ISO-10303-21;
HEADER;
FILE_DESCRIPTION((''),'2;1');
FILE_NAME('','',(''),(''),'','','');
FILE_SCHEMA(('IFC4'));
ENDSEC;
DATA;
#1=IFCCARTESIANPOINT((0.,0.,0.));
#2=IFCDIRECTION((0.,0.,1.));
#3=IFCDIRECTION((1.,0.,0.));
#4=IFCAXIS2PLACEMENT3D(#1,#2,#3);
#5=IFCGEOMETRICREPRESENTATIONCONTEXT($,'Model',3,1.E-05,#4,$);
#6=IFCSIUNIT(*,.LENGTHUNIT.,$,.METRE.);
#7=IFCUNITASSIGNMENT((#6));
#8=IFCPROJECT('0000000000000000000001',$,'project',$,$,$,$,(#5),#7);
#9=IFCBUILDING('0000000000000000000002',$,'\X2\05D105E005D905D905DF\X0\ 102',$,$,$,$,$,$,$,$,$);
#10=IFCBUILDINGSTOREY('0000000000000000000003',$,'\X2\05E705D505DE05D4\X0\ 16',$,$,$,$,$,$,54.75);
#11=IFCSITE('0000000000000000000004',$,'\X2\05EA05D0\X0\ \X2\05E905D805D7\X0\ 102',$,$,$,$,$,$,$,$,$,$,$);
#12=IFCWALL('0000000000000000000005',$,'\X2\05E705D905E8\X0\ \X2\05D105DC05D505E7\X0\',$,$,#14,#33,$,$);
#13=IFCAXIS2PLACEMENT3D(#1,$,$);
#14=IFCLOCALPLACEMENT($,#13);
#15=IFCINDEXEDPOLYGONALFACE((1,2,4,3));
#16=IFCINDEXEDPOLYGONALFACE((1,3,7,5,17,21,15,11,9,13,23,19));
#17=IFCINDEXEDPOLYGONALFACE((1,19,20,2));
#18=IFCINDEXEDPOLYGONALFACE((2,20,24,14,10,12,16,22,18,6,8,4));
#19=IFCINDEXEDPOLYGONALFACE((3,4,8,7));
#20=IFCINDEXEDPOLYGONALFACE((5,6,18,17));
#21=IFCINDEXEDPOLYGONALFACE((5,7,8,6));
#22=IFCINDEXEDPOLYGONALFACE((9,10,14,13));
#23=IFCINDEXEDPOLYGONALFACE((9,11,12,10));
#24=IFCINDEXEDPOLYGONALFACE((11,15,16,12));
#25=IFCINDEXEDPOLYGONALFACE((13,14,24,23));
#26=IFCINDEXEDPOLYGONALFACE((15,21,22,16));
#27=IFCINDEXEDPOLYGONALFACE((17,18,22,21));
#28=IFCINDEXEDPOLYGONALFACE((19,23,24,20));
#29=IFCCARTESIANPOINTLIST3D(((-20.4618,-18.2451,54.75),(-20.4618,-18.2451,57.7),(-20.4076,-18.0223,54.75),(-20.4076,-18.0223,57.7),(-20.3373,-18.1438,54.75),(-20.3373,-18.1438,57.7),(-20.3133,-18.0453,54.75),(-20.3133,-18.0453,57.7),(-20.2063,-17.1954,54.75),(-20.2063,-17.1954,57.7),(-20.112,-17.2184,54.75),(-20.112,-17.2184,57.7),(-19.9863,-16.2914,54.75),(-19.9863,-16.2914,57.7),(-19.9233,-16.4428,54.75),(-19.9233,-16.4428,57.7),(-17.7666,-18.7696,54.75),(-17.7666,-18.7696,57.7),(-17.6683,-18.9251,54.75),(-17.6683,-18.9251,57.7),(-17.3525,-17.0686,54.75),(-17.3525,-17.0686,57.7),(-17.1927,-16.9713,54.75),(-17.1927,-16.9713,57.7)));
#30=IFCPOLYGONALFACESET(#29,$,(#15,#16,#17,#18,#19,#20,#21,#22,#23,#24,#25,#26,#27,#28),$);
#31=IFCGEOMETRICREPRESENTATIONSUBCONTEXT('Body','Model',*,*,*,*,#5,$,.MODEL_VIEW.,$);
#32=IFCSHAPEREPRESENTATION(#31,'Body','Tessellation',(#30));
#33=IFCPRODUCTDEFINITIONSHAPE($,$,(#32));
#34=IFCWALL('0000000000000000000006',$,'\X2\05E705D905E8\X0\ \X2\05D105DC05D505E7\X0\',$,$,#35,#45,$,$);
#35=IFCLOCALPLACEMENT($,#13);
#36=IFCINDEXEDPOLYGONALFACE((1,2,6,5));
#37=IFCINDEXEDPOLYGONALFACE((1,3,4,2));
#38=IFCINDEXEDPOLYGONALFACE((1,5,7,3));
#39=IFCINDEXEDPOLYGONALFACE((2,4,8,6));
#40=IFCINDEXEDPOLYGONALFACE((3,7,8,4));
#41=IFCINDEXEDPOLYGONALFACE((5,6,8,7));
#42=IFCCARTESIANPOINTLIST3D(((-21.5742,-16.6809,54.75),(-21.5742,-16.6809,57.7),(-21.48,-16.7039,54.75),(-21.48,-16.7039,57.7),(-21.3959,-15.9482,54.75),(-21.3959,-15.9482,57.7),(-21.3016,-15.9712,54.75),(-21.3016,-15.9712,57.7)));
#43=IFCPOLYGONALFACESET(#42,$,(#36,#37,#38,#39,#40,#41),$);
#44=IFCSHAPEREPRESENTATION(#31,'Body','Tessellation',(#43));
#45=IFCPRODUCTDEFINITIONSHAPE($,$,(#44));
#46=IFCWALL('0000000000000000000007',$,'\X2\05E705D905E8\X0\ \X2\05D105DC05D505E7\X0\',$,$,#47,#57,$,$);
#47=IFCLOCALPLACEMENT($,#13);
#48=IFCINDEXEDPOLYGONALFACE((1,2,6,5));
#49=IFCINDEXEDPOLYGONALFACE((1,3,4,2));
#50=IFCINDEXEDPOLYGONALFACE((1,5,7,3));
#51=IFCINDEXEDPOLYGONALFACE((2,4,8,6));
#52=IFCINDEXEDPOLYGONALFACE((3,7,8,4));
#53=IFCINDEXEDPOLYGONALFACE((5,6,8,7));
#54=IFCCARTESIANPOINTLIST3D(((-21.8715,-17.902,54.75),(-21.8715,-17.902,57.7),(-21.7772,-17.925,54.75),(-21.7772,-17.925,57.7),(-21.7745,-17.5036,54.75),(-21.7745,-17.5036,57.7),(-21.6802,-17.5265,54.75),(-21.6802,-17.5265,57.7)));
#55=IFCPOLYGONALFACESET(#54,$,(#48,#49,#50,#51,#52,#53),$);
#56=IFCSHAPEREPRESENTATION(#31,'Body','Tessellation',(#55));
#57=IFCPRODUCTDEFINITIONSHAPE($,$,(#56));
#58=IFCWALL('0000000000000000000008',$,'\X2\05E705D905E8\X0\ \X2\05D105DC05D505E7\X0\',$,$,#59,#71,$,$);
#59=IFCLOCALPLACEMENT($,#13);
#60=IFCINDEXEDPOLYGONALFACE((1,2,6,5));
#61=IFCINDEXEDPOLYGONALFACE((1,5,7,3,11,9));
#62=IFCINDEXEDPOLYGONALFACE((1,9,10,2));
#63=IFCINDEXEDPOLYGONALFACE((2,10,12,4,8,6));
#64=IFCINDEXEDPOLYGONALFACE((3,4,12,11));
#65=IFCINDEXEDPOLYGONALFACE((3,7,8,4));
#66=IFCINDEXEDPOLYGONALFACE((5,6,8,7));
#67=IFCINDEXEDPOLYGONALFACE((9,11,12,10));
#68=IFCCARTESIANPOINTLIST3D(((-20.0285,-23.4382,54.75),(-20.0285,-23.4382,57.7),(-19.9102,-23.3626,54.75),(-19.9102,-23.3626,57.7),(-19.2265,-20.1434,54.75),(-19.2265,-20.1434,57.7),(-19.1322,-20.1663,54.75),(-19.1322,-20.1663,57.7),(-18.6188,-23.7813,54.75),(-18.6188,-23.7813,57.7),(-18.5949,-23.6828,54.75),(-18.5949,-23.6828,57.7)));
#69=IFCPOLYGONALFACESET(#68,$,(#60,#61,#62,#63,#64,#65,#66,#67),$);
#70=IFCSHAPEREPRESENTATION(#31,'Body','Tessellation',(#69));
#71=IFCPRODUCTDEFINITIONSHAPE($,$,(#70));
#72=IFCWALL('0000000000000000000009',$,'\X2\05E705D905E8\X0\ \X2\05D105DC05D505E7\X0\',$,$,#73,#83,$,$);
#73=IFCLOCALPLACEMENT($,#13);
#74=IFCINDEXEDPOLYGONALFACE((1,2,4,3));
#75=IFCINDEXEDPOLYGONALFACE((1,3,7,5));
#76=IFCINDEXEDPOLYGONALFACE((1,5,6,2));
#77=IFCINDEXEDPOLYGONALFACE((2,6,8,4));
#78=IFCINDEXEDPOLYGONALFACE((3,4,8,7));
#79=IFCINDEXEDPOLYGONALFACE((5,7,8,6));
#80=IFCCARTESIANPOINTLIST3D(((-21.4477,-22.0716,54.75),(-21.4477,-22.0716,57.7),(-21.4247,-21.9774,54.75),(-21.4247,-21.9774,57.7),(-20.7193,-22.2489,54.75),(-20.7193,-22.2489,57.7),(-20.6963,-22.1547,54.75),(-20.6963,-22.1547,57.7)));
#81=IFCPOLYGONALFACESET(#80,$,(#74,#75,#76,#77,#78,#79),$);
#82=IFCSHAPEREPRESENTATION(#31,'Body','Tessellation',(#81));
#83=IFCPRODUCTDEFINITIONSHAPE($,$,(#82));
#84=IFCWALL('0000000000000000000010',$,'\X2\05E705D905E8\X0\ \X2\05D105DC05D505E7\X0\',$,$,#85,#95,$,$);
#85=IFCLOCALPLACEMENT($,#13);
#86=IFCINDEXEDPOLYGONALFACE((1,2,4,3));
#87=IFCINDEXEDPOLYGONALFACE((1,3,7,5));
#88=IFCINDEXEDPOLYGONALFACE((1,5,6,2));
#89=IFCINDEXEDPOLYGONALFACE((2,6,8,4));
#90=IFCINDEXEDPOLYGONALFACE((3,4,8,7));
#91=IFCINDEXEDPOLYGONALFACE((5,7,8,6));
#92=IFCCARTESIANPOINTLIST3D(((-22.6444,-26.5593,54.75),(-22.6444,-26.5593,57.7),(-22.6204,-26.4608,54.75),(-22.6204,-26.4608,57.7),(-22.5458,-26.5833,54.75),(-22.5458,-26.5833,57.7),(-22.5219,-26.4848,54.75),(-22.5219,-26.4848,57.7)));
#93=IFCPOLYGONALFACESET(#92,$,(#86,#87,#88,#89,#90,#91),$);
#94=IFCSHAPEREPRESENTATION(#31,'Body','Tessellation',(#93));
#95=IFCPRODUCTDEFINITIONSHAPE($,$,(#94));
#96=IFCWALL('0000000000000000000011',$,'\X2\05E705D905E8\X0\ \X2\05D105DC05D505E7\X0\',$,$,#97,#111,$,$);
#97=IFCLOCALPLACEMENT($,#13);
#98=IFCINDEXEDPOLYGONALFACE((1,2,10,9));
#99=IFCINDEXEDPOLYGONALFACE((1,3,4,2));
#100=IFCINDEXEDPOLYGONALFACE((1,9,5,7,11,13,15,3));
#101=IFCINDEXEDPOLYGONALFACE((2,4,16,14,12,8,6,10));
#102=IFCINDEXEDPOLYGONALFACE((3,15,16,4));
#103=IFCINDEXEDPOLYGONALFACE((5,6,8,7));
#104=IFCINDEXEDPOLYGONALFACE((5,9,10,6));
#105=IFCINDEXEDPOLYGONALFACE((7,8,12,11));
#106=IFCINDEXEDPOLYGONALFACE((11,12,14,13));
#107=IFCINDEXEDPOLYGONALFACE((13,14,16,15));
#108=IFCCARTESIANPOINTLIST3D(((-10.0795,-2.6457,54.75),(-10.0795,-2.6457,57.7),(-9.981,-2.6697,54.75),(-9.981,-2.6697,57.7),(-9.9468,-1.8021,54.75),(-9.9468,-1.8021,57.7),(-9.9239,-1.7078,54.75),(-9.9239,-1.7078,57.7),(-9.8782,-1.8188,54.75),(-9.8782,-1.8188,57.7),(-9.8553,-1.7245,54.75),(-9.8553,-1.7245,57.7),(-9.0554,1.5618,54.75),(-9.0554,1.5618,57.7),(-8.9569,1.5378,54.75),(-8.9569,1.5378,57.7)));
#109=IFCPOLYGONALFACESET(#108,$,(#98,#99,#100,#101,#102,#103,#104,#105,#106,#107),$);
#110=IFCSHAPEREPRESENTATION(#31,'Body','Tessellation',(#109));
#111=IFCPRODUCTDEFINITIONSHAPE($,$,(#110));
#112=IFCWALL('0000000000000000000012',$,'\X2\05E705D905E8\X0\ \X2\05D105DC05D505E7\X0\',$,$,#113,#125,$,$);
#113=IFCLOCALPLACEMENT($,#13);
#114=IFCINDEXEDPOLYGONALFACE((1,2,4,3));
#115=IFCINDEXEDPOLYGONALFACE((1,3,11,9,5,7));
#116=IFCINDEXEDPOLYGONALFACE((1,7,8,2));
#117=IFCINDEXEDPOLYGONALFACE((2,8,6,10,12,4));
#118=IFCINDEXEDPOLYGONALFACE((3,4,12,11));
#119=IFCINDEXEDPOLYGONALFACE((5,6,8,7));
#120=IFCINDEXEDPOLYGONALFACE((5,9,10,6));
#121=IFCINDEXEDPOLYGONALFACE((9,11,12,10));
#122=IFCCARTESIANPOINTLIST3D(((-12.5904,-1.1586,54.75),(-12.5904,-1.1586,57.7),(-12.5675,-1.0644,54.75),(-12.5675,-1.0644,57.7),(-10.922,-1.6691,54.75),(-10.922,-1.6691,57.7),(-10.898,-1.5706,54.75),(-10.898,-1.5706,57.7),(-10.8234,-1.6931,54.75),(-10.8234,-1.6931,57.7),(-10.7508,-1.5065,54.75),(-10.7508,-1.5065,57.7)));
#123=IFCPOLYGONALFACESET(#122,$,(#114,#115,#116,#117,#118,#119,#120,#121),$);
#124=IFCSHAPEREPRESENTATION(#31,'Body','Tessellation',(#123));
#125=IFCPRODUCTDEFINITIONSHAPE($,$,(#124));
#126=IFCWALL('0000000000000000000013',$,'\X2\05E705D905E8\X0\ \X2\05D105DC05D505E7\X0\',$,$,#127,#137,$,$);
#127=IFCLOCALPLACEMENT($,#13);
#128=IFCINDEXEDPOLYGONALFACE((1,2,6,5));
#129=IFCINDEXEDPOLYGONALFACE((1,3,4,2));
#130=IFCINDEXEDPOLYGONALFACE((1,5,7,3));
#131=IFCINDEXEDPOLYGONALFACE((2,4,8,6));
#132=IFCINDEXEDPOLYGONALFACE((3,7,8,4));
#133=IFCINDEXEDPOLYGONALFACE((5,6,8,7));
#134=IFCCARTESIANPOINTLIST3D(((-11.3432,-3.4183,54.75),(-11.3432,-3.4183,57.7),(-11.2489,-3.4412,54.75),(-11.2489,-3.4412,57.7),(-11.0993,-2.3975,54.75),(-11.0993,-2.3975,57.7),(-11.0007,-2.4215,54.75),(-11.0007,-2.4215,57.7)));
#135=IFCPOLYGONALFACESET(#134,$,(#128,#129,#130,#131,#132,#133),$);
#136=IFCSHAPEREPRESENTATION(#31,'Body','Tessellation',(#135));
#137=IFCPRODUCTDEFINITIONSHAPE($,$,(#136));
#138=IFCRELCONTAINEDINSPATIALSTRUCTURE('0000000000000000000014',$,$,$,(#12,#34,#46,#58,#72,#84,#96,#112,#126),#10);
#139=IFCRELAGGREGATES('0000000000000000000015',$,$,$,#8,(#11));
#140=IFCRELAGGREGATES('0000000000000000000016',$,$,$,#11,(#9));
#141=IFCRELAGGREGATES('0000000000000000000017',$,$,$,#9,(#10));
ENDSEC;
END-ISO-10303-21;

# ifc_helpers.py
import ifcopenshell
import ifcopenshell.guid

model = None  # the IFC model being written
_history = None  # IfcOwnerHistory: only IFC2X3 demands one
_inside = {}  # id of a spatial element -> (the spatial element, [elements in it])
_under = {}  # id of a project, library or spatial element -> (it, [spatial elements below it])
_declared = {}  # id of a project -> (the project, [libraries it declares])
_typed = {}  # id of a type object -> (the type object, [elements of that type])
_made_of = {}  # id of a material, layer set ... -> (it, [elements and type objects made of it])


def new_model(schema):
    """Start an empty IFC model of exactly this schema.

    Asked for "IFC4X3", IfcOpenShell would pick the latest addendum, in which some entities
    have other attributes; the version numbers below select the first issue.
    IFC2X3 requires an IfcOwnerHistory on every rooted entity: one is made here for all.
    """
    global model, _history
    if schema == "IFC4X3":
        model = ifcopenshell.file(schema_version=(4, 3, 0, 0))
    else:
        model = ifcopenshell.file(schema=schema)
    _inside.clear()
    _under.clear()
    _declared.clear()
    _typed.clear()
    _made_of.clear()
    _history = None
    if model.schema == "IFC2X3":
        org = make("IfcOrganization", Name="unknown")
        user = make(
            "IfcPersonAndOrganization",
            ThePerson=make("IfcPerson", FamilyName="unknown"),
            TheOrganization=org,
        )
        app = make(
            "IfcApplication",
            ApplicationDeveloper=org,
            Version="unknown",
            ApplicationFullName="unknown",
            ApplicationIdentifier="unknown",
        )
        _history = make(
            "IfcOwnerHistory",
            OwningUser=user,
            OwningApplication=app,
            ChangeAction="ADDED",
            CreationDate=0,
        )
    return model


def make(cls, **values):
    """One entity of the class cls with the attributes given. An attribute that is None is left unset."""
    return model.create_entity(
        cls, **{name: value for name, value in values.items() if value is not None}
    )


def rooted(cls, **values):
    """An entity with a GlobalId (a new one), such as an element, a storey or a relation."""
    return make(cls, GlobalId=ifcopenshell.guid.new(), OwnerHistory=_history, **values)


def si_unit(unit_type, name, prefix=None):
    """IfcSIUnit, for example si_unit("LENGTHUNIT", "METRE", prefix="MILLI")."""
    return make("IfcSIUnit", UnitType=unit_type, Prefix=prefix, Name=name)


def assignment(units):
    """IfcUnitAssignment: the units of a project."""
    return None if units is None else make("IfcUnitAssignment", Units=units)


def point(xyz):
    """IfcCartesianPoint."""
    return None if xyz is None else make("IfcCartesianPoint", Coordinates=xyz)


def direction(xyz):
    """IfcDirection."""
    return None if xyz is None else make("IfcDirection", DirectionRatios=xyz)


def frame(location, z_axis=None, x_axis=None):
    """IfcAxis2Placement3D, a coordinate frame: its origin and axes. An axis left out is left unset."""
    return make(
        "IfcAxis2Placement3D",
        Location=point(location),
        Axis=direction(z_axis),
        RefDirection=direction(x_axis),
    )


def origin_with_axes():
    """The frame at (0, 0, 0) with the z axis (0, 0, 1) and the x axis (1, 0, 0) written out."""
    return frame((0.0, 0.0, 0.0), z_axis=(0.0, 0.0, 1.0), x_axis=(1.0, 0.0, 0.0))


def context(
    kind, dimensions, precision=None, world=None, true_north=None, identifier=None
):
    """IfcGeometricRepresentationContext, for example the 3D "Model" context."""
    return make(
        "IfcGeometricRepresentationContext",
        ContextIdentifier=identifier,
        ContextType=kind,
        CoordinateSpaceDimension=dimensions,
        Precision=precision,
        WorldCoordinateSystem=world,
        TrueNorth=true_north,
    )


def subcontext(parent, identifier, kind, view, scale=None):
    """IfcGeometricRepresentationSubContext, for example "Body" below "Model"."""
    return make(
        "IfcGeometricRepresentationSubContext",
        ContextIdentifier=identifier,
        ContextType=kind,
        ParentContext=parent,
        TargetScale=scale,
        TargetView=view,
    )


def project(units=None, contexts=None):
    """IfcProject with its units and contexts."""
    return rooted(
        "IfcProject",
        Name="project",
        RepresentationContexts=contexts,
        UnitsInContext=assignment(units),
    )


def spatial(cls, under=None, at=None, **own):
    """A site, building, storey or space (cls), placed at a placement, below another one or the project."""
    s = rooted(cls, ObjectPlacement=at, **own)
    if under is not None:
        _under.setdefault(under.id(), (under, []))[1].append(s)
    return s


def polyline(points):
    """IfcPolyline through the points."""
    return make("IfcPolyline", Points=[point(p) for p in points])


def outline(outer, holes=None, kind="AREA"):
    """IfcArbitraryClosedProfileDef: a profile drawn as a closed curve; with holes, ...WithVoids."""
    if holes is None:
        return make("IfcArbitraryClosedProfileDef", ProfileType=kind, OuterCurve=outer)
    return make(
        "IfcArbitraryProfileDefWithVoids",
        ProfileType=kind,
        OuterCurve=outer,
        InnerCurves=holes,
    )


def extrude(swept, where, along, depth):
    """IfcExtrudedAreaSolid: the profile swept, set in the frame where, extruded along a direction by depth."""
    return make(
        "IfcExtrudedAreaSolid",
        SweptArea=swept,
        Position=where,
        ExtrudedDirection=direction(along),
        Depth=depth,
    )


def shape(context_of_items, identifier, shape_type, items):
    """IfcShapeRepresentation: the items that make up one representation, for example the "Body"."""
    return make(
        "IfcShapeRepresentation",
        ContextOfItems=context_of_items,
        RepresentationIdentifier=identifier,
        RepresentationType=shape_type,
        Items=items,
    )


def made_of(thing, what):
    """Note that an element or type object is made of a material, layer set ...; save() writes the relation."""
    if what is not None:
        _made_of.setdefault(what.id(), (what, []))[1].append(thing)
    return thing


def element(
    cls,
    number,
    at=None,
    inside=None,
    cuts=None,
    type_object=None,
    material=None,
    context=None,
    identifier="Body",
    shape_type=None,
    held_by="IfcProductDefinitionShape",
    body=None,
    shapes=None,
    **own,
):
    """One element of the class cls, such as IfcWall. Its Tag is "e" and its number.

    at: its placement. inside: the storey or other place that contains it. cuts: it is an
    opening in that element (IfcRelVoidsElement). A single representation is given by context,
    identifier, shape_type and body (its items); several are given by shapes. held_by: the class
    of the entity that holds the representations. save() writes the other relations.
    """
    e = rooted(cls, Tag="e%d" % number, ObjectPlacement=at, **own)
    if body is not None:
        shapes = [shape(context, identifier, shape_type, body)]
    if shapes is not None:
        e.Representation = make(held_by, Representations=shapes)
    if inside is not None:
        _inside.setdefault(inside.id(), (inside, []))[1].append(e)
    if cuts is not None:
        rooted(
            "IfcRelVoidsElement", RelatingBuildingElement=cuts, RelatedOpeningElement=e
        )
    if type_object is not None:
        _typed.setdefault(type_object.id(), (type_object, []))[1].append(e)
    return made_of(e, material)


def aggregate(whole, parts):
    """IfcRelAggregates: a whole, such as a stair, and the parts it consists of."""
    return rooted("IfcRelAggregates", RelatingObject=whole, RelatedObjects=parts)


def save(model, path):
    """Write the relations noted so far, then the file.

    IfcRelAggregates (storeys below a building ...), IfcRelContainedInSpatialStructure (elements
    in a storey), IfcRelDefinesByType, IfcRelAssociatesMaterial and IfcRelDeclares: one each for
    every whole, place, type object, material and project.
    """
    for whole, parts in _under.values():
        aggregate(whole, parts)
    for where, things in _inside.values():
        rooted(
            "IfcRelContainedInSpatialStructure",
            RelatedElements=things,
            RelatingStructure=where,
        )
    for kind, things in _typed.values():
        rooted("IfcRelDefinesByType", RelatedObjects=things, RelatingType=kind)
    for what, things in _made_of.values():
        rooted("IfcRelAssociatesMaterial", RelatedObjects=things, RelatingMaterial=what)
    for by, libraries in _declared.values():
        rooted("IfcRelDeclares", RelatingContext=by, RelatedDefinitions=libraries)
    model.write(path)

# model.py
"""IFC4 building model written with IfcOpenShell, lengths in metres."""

from ifc_helpers import new_model, si_unit, frame, origin_with_axes, context, subcontext, project, spatial, polyline, outline, extrude, element, save


model = new_model("IFC4")

# Units and contexts
model_context = context("Model", 3, precision=1e-05, world=origin_with_axes())
body_context = subcontext(model_context, "Body", "Model", "MODEL_VIEW")
ifc_project = project(units=[si_unit("LENGTHUNIT", "METRE")], contexts=[model_context])

# Site, building, storey
site = spatial("IfcSite", under=ifc_project, Name="תא שטח 102")
building = spatial("IfcBuilding", under=site, Name="בניין 102")
storey = spatial("IfcBuildingStorey", under=building, Name="קומה 16", Elevation=54.75)

# Walls
element("IfcWall", 1, inside=storey, Name="קיר בלוק", context=body_context, shape_type="SweptSolid", body=[
    extrude(outline(polyline([(-19.9233, -16.4428), (-17.3525, -17.0686), (-17.7666, -18.7696), (-20.3373, -18.1438), (-20.3133, -18.0453), (-20.4076, -18.0223), (-20.4618, -18.2451), (-17.6683, -18.9251), (-17.1927, -16.9713), (-19.9863, -16.2914), (-20.2063, -17.1954), (-20.112, -17.2184), (-19.9233, -16.4428)])), frame((0.0, 0.0, 54.75)), (0.0, 0.0, 1.0), 2.95),
])
element("IfcWall", 2, inside=storey, Name="קיר בלוק", context=body_context, shape_type="SweptSolid", body=[
    extrude(outline(polyline([(-21.3959, -15.9482), (-21.5742, -16.6809), (-21.48, -16.7039), (-21.3016, -15.9712), (-21.3959, -15.9482)])), frame((0.0, 0.0, 54.75)), (0.0, 0.0, 1.0), 2.95),
])
element("IfcWall", 3, inside=storey, Name="קיר בלוק", context=body_context, shape_type="SweptSolid", body=[
    extrude(outline(polyline([(-21.8715, -17.902), (-21.7772, -17.925), (-21.6802, -17.5265), (-21.7745, -17.5036), (-21.8715, -17.902)])), frame((0.0, 0.0, 54.75)), (0.0, 0.0, 1.0), 2.95),
])
element("IfcWall", 4, inside=storey, Name="קיר בלוק", context=body_context, shape_type="SweptSolid", body=[
    extrude(outline(polyline([(-18.5949, -23.6828), (-19.9102, -23.3626), (-19.1322, -20.1663), (-19.2265, -20.1434), (-20.0285, -23.4382), (-18.6188, -23.7813), (-18.5949, -23.6828)])), frame((0.0, 0.0, 54.75)), (0.0, 0.0, 1.0), 2.95),
])
element("IfcWall", 5, inside=storey, Name="קיר בלוק", context=body_context, shape_type="SweptSolid", body=[
    extrude(outline(polyline([(-21.4477, -22.0716), (-20.7193, -22.2489), (-20.6963, -22.1547), (-21.4247, -21.9774), (-21.4477, -22.0716)])), frame((0.0, 0.0, 54.75)), (0.0, 0.0, 1.0), 2.95),
])
element("IfcWall", 6, inside=storey, Name="קיר בלוק", context=body_context, shape_type="SweptSolid", body=[
    extrude(outline(polyline([(-22.6444, -26.5593), (-22.5458, -26.5833), (-22.5219, -26.4848), (-22.6204, -26.4608), (-22.6444, -26.5593)])), frame((0.0, 0.0, 54.75)), (0.0, 0.0, 1.0), 2.95),
])
element("IfcWall", 7, inside=storey, Name="קיר בלוק", context=body_context, shape_type="SweptSolid", body=[
    extrude(outline(polyline([(-10.0795, -2.6457), (-9.981, -2.6697), (-8.9569, 1.5378), (-9.0554, 1.5618), (-9.8553, -1.7245), (-9.9239, -1.7078), (-9.9468, -1.8021), (-9.8782, -1.8188), (-10.0795, -2.6457)])), frame((0.0, 0.0, 54.75)), (0.0, 0.0, 1.0), 2.95),
])
element("IfcWall", 8, inside=storey, Name="קיר בלוק", context=body_context, shape_type="SweptSolid", body=[
    extrude(outline(polyline([(-10.922, -1.6691), (-10.8234, -1.6931), (-10.7508, -1.5065), (-12.5675, -1.0644), (-12.5904, -1.1586), (-10.898, -1.5706), (-10.922, -1.6691)])), frame((0.0, 0.0, 54.75)), (0.0, 0.0, 1.0), 2.95),
])
element("IfcWall", 9, inside=storey, Name="קיר בלוק", context=body_context, shape_type="SweptSolid", body=[
    extrude(outline(polyline([(-11.2489, -3.4412), (-11.0007, -2.4215), (-11.0993, -2.3975), (-11.3432, -3.4183), (-11.2489, -3.4412)])), frame((0.0, 0.0, 54.75)), (0.0, 0.0, 1.0), 2.95),
])

save(model, "model.ifc")
